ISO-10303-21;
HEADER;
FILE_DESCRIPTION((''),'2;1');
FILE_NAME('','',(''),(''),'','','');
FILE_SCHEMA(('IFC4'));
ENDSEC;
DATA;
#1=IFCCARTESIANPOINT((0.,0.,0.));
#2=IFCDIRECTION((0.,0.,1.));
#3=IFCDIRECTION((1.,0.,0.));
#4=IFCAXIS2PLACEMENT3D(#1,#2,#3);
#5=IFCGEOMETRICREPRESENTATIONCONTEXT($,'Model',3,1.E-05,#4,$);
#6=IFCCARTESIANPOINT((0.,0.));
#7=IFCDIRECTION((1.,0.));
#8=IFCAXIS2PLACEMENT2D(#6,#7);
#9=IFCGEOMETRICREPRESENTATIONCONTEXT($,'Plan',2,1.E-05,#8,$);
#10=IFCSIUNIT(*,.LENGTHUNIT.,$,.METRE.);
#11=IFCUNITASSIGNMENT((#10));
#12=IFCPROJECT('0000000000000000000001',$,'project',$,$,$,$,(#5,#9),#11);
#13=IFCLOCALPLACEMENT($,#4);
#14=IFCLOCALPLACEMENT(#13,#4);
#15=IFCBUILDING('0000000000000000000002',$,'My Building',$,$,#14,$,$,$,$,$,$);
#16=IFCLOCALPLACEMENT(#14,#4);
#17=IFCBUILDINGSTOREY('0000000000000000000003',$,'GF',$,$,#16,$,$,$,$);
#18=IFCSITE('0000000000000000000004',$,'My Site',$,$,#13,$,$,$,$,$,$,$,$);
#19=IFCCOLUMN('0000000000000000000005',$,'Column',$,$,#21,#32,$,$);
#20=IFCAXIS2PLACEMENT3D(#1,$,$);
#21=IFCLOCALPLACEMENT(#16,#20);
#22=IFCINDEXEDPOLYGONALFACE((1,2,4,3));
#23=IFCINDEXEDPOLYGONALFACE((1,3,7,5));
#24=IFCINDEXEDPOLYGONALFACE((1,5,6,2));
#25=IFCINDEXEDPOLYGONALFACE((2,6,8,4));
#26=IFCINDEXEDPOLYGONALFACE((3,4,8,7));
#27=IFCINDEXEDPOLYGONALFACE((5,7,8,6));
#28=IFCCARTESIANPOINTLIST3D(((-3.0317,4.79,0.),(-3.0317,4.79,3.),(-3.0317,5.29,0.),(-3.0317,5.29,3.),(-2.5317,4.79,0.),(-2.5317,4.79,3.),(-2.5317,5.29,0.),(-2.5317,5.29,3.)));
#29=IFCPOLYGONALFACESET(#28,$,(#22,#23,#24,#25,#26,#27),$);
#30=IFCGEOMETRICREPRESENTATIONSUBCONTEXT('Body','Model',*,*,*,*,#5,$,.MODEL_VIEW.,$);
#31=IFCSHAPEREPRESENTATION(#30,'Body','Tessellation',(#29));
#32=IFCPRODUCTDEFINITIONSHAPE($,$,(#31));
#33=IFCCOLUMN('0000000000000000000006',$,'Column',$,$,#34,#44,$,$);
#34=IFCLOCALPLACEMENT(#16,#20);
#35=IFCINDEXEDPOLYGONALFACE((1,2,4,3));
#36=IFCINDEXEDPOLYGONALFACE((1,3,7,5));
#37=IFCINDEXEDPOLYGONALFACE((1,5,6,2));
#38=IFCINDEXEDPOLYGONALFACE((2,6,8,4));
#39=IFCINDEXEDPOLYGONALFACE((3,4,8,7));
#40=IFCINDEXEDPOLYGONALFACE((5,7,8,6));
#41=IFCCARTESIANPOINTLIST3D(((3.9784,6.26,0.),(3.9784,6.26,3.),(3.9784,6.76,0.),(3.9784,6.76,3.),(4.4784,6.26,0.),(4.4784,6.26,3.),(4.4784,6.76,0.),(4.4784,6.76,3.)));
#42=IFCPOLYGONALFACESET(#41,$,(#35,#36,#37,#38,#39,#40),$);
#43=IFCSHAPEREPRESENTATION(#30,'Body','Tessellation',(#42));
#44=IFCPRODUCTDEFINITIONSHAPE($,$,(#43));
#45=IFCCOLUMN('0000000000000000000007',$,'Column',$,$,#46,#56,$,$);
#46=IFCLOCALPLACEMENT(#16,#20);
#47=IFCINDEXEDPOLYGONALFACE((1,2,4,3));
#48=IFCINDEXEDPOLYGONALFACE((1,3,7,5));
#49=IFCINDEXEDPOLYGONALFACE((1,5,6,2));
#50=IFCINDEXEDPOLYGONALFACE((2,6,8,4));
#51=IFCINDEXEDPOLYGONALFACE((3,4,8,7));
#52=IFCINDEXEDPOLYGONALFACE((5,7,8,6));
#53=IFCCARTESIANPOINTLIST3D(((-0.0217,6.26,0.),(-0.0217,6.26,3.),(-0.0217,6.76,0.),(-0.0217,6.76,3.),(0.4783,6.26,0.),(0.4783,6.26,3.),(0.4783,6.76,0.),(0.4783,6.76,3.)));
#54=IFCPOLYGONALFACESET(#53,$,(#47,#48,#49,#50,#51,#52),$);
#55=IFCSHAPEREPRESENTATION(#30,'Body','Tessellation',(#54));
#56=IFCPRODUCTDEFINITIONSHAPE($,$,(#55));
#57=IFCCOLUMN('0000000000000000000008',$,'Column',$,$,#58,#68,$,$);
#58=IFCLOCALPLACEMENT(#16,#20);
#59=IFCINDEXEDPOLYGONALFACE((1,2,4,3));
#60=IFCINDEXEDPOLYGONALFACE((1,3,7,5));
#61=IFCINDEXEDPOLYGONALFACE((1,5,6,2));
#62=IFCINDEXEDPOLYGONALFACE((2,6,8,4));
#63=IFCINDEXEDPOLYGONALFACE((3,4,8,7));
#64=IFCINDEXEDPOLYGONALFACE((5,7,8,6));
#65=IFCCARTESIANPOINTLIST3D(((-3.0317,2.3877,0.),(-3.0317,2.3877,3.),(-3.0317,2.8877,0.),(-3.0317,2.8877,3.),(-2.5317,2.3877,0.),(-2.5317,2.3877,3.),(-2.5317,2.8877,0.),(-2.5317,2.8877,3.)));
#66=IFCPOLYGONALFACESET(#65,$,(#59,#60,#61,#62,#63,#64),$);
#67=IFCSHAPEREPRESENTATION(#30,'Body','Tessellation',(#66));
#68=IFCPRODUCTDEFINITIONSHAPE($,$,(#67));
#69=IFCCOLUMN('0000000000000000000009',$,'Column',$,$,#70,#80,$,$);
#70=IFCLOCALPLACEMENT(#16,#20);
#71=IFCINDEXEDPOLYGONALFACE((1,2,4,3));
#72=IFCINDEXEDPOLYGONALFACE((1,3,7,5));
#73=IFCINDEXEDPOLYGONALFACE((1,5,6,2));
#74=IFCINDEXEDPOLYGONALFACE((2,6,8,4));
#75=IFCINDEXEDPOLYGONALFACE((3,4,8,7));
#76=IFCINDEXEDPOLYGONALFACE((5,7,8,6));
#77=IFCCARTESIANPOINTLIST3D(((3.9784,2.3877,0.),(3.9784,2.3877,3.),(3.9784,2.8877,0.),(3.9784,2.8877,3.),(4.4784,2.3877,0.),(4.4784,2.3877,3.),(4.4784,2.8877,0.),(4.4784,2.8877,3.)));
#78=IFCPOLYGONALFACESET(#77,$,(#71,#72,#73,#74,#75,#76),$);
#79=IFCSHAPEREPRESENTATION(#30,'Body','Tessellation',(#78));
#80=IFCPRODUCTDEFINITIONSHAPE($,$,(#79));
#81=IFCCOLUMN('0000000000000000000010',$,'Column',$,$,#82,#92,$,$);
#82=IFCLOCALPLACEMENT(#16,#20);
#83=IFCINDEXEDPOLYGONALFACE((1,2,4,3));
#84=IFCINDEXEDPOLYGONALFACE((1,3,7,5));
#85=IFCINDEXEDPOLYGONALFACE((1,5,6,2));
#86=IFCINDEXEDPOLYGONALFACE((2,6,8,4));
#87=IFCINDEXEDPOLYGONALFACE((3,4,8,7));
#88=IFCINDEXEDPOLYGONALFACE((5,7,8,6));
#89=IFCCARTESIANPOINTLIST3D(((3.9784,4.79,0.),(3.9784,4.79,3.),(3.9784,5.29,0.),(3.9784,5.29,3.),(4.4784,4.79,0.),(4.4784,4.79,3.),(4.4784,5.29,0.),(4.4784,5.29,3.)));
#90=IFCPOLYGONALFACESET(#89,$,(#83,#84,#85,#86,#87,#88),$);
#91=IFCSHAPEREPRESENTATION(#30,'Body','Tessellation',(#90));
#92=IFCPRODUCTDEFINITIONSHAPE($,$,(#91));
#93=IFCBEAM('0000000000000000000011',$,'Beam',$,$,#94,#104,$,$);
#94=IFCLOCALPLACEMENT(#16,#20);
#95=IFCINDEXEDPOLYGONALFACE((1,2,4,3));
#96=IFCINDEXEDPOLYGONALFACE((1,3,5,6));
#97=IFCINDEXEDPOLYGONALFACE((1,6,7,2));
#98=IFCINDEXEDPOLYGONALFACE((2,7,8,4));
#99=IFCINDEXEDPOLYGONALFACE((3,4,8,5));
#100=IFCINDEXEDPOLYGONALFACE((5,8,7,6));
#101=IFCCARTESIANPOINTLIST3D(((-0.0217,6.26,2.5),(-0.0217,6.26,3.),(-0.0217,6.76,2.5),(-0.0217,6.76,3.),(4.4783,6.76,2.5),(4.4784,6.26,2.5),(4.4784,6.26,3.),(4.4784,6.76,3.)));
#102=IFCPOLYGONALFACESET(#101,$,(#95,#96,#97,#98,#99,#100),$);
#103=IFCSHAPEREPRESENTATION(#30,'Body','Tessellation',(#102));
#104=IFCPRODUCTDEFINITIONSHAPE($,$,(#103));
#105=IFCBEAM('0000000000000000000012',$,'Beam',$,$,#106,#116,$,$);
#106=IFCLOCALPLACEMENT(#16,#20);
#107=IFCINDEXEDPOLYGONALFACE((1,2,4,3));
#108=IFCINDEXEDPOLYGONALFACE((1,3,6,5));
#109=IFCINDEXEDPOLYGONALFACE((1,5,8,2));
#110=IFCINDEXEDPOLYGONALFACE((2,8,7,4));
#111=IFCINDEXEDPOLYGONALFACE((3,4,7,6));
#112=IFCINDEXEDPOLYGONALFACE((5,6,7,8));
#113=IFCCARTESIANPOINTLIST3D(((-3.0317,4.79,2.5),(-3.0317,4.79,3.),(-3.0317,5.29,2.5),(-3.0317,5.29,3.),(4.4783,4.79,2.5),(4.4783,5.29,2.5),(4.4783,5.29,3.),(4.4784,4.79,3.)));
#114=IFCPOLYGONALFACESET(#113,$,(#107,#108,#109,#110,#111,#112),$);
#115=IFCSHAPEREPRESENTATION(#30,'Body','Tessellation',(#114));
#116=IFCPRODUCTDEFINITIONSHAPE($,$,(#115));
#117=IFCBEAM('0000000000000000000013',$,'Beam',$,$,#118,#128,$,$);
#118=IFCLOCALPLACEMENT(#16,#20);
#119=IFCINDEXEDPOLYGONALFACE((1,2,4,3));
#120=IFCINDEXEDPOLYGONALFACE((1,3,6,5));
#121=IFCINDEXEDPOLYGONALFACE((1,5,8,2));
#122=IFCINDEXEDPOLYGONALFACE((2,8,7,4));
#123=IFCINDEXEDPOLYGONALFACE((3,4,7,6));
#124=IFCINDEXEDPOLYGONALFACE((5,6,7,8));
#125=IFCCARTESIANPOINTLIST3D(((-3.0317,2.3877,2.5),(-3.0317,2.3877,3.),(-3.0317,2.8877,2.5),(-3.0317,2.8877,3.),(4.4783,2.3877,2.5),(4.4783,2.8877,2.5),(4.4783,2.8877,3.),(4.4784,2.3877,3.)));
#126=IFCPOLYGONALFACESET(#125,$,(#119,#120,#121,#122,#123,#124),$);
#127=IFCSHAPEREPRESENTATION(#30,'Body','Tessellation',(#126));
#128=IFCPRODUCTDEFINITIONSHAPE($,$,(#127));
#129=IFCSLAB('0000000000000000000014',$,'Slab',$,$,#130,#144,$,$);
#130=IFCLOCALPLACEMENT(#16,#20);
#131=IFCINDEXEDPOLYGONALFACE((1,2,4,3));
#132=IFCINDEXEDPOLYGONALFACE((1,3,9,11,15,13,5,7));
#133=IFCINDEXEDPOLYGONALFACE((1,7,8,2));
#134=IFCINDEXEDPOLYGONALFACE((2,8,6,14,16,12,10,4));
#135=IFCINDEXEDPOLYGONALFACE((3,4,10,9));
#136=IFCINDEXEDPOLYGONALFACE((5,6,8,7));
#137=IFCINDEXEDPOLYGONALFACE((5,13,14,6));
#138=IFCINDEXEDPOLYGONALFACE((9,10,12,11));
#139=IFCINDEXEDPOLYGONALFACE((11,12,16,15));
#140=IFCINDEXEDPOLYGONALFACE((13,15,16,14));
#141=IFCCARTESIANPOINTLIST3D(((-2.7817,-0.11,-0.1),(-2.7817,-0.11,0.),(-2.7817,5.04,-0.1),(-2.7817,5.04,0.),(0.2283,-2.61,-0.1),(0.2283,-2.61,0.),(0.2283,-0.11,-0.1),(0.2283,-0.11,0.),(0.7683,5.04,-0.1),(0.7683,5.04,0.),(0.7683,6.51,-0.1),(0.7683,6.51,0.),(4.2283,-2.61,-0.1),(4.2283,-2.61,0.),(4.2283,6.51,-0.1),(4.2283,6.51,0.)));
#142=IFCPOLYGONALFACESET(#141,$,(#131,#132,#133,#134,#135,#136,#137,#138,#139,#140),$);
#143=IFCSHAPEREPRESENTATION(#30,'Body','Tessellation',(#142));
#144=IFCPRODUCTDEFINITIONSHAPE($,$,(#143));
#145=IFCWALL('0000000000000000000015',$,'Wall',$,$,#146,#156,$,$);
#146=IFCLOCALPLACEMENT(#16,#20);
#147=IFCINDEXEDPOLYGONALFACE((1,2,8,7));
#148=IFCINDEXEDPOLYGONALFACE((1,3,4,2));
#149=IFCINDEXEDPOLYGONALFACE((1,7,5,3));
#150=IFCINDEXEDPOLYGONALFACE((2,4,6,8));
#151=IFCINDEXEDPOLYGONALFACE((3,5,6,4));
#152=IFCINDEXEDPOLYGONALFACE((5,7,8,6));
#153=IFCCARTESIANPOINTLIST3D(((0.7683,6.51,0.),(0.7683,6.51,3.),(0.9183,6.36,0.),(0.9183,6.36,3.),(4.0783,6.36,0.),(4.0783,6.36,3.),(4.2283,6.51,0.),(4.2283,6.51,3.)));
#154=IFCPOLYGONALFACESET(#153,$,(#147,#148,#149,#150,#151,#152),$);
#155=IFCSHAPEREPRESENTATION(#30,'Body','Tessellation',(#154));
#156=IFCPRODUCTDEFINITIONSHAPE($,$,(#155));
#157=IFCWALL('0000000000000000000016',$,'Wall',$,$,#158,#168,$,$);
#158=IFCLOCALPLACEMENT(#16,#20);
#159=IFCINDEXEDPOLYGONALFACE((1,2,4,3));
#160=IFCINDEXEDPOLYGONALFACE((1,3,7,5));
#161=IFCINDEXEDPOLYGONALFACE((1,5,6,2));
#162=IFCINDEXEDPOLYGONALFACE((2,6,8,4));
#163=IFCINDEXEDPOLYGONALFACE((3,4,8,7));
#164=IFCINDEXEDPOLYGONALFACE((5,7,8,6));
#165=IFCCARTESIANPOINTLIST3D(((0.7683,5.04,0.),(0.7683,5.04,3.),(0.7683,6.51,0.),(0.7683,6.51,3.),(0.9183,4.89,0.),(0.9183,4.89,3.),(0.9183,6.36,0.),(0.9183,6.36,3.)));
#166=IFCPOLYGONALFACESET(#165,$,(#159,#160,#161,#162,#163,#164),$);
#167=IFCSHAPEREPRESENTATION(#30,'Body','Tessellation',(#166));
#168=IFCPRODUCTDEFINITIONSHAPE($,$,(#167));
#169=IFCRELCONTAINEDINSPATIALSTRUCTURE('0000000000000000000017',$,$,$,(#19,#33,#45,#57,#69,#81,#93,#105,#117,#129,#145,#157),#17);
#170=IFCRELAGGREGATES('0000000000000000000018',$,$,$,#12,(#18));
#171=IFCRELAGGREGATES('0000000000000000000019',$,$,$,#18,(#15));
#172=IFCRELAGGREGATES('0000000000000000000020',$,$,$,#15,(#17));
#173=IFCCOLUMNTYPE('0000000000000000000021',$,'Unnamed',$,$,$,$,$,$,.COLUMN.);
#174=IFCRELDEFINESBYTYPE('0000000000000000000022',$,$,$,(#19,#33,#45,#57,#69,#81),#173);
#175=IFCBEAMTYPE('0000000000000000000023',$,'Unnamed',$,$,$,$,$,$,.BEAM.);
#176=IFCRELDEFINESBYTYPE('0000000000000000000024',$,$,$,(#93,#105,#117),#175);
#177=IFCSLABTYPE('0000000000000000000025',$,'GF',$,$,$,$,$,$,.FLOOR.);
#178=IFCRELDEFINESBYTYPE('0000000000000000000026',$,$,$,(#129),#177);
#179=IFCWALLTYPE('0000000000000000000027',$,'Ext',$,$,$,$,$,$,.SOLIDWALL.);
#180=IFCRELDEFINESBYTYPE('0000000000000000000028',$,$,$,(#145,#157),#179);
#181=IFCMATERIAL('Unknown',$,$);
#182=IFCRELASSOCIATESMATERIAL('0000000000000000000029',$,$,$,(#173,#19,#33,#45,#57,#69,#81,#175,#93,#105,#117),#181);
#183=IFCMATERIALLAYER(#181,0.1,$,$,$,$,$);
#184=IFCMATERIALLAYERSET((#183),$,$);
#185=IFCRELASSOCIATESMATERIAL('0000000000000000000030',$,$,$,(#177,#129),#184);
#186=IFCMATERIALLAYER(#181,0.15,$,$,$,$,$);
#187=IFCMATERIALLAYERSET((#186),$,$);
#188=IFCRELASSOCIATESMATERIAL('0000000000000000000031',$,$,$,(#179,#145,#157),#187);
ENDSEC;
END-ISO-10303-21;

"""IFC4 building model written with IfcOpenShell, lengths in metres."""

from ifc_helpers import new_model, si_unit, frame, origin_with_axes, origin_2d_with_axis, place, context, subcontext, project, spatial, line, indexed_curve, outline, extrude, material, layer, layer_set, layer_usage, material_profile, profile_set, profile_usage, type_object, element, save


model = new_model("IFC4")

# Units and contexts
model_context = context("Model", 3, precision=1e-05, world=origin_with_axes())
plan_context = context("Plan", 2, precision=1e-05, world=origin_2d_with_axis())
body_context_1 = subcontext(model_context, "Body", "Model", "MODEL_VIEW")
ifc_project = project(units=[si_unit("LENGTHUNIT", "METRE")], contexts=[model_context, plan_context])

# Site, building, storey
site_placement = place(None, origin_with_axes())
site = spatial("IfcSite", under=ifc_project, at=site_placement, Name="My Site")
building_placement = place(site_placement, origin_with_axes())
building = spatial("IfcBuilding", under=site, at=building_placement, Name="My Building")
storey_placement = place(building_placement, origin_with_axes())
storey = spatial("IfcBuildingStorey", under=building, at=storey_placement, Name="GF")

# Columns
ifc_material = material(Name="Unknown")
ifc_material_profile_1 = material_profile(ifc_material, outline(indexed_curve([(-0.25, -0.25), (0.25, -0.25), (0.25, 0.25), (-0.25, 0.25), (-0.25, -0.25)])))
ifc_profile_set_1 = profile_set([ifc_material_profile_1])
ifc_profile_usage_1 = profile_usage(ifc_profile_set_1, cardinal=5)
column_type = type_object("IfcColumnType", Name="Unnamed", PredefinedType="COLUMN", material=ifc_profile_set_1)
column_1_placement = place(storey_placement, frame((-2.7817, 5.04, 0.0), z_axis=(0.0, 0.0, 1.0), x_axis=(1.0, 0.0, 0.0)))
element("IfcColumn", 1, at=column_1_placement, inside=storey, type_object=column_type, material=ifc_profile_usage_1, Name="Column", context=body_context_1, shape_type="SweptSolid", body=[
    extrude(outline(indexed_curve([(-0.25, -0.25), (0.25, -0.25), (0.25, 0.25), (-0.25, 0.25), (-0.25, -0.25)])), origin_with_axes(), (0.0, 0.0, 1.0), 3.0),
])
ifc_profile_usage_2 = profile_usage(ifc_profile_set_1, cardinal=5)
column_2_placement = place(storey_placement, frame((4.2284, 6.51, 0.0), z_axis=(0.0, 0.0, 1.0), x_axis=(1.0, 0.0, 0.0)))
element("IfcColumn", 2, at=column_2_placement, inside=storey, type_object=column_type, material=ifc_profile_usage_2, Name="Column", context=body_context_1, shape_type="SweptSolid", body=[
    extrude(outline(indexed_curve([(-0.25, -0.25), (0.25, -0.25), (0.25, 0.25), (-0.25, 0.25), (-0.25, -0.25)])), origin_with_axes(), (0.0, 0.0, 1.0), 3.0),
])
ifc_profile_usage_3 = profile_usage(ifc_profile_set_1, cardinal=5)
column_3_placement = place(storey_placement, frame((0.2283, 6.51, 0.0), z_axis=(0.0, 0.0, 1.0), x_axis=(1.0, 0.0, 0.0)))
element("IfcColumn", 3, at=column_3_placement, inside=storey, type_object=column_type, material=ifc_profile_usage_3, Name="Column", context=body_context_1, shape_type="SweptSolid", body=[
    extrude(outline(indexed_curve([(-0.25, -0.25), (0.25, -0.25), (0.25, 0.25), (-0.25, 0.25), (-0.25, -0.25)])), origin_with_axes(), (0.0, 0.0, 1.0), 3.0),
])
ifc_profile_usage_4 = profile_usage(ifc_profile_set_1, cardinal=5)
column_4_placement = place(storey_placement, frame((-2.7817, 2.6377, 0.0), z_axis=(0.0, 0.0, 1.0), x_axis=(1.0, 0.0, 0.0)))
element("IfcColumn", 4, at=column_4_placement, inside=storey, type_object=column_type, material=ifc_profile_usage_4, Name="Column", context=body_context_1, shape_type="SweptSolid", body=[
    extrude(outline(indexed_curve([(-0.25, -0.25), (0.25, -0.25), (0.25, 0.25), (-0.25, 0.25), (-0.25, -0.25)])), origin_with_axes(), (0.0, 0.0, 1.0), 3.0),
])
ifc_profile_usage_5 = profile_usage(ifc_profile_set_1, cardinal=5)
column_5_placement = place(storey_placement, frame((4.2284, 2.6377, 0.0), z_axis=(0.0, 0.0, 1.0), x_axis=(1.0, 0.0, 0.0)))
element("IfcColumn", 5, at=column_5_placement, inside=storey, type_object=column_type, material=ifc_profile_usage_5, Name="Column", context=body_context_1, shape_type="SweptSolid", body=[
    extrude(outline(indexed_curve([(-0.25, -0.25), (0.25, -0.25), (0.25, 0.25), (-0.25, 0.25), (-0.25, -0.25)])), origin_with_axes(), (0.0, 0.0, 1.0), 3.0),
])
ifc_profile_usage_6 = profile_usage(ifc_profile_set_1, cardinal=5)
column_6_placement = place(storey_placement, frame((4.2284, 5.04, 0.0), z_axis=(0.0, 0.0, 1.0), x_axis=(1.0, 0.0, 0.0)))
element("IfcColumn", 6, at=column_6_placement, inside=storey, type_object=column_type, material=ifc_profile_usage_6, Name="Column", context=body_context_1, shape_type="SweptSolid", body=[
    extrude(outline(indexed_curve([(-0.25, -0.25), (0.25, -0.25), (0.25, 0.25), (-0.25, 0.25), (-0.25, -0.25)])), origin_with_axes(), (0.0, 0.0, 1.0), 3.0),
])

# Beams
ifc_material_profile_2 = material_profile(ifc_material, outline(indexed_curve([(-0.25, -0.25), (0.25, -0.25), (0.25, 0.25), (-0.25, 0.25), (-0.25, -0.25)])))
ifc_profile_set_2 = profile_set([ifc_material_profile_2])
ifc_profile_usage_7 = profile_usage(ifc_profile_set_2, cardinal=7)
beam_type = type_object("IfcBeamType", Name="Unnamed", PredefinedType="BEAM", material=ifc_profile_set_2)
beam_1_placement = place(storey_placement, frame((4.4784, 6.26, 3.0), z_axis=(-1.0, 0.0, 0.0), x_axis=(0.0, -1.0, 0.0)))
element("IfcBeam", 7, at=beam_1_placement, inside=storey, type_object=beam_type, material=ifc_profile_usage_7, Name="Beam", context=body_context_1, shape_type="SweptSolid", body=[
    extrude(outline(indexed_curve([(-0.25, -0.25), (0.25, -0.25), (0.25, 0.25), (-0.25, 0.25), (-0.25, -0.25)])), frame((-0.25, -0.25, 0.0), z_axis=(0.0, 0.0, 1.0), x_axis=(1.0, 0.0, 0.0)), (0.0, 0.0, 1.0), 4.5),
])
ifc_profile_usage_8 = profile_usage(ifc_profile_set_2, cardinal=7)
beam_2_placement = place(storey_placement, frame((4.4784, 4.79, 3.0), z_axis=(-1.0, -0.000001, 0.000001), x_axis=(0.000001, -1.0, 0.0)))
element("IfcBeam", 8, at=beam_2_placement, inside=storey, type_object=beam_type, material=ifc_profile_usage_8, Name="Beam", context=body_context_1, shape_type="SweptSolid", body=[
    extrude(outline(indexed_curve([(-0.25, -0.25), (0.25, -0.25), (0.25, 0.25), (-0.25, 0.25), (-0.25, -0.25)])), frame((-0.25, -0.25, 0.0), z_axis=(0.0, 0.0, 1.0), x_axis=(1.0, 0.0, 0.0)), (0.0, 0.0, 1.0), 7.51),
])
ifc_profile_usage_9 = profile_usage(ifc_profile_set_2, cardinal=7)
beam_3_placement = place(storey_placement, frame((4.4784, 2.3877, 3.0), z_axis=(-1.0, -0.000001, 0.000001), x_axis=(0.000001, -1.0, 0.0)))
element("IfcBeam", 9, at=beam_3_placement, inside=storey, type_object=beam_type, material=ifc_profile_usage_9, Name="Beam", context=body_context_1, shape_type="SweptSolid", body=[
    extrude(outline(indexed_curve([(-0.25, -0.25), (0.25, -0.25), (0.25, 0.25), (-0.25, 0.25), (-0.25, -0.25)])), frame((-0.25, -0.25, 0.0), z_axis=(0.0, 0.0, 1.0), x_axis=(1.0, 0.0, 0.0)), (0.0, 0.0, 1.0), 7.51),
])

# Slab
ifc_layer_1 = layer(ifc_material, 0.1)
ifc_layer_set_1 = layer_set([ifc_layer_1])
ifc_layer_usage_1 = layer_usage(ifc_layer_set_1, "AXIS3", "POSITIVE", -0.1)
slab_type = type_object("IfcSlabType", Name="GF", PredefinedType="FLOOR", material=ifc_layer_set_1)
slab_placement = place(storey_placement, frame((-2.7817, 5.04, 0.0), z_axis=(0.0, 0.0, 1.0), x_axis=(1.0, 0.0, 0.0)))
element("IfcSlab", 10, at=slab_placement, inside=storey, type_object=slab_type, material=ifc_layer_usage_1, Name="Slab", context=body_context_1, shape_type="SweptSolid", body=[
    extrude(outline(indexed_curve([(0.0, 0.0), (3.55, 0.0), (3.55, 1.47), (7.01, 1.47), (7.01, -7.65), (3.01, -7.65), (3.01, -5.15), (0.0, -5.15), (0.0, 0.0)])), frame((0.0, 0.0, -0.1), z_axis=(0.0, 0.0, 1.0), x_axis=(1.0, 0.0, 0.0)), (0.0, 0.0, 1.0), 0.1),
])

# Walls
ifc_layer_2 = layer(ifc_material, 0.15)
ifc_layer_set_2 = layer_set([ifc_layer_2])
ifc_layer_usage_2 = layer_usage(ifc_layer_set_2, "AXIS2", "POSITIVE", 0.0)
wall_type_1 = type_object("IfcWallType", Name="Ext", PredefinedType="SOLIDWALL", material=ifc_layer_set_2)
wall_1_placement = place(storey_placement, frame((4.2283, 6.51, 0.0), z_axis=(0.0, 0.0, 1.0), x_axis=(-1.0, 0.0, 0.0)))
element("IfcWall", 11, at=wall_1_placement, inside=storey, type_object=wall_type_1, material=ifc_layer_usage_2, Name="Wall", context=body_context_1, shape_type="SweptSolid", body=[
    extrude(outline(indexed_curve([(0.0, 0.0), (0.15, 0.15), (3.31, 0.15), (3.46, 0.0)], segments=[line(1, 2, 3, 4, 1)])), origin_with_axes(), (0.0, 0.0, 1.0), 3.0),
])
ifc_layer_usage_3 = layer_usage(ifc_layer_set_2, "AXIS2", "POSITIVE", 0.0)
wall_2_placement = place(storey_placement, frame((0.7683, 6.51, 0.0), z_axis=(0.0, 0.0, 1.0), x_axis=(0.0, -1.0, 0.0)))
element("IfcWall", 12, at=wall_2_placement, inside=storey, type_object=wall_type_1, material=ifc_layer_usage_3, Name="Wall", context=body_context_1, shape_type="SweptSolid", body=[
    extrude(outline(indexed_curve([(0.0, 0.0), (0.15, 0.15), (1.62, 0.15), (1.47, 0.0)], segments=[line(1, 2, 3, 4, 1)])), origin_with_axes(), (0.0, 0.0, 1.0), 3.0),
])

save(model, "model.ifc")
